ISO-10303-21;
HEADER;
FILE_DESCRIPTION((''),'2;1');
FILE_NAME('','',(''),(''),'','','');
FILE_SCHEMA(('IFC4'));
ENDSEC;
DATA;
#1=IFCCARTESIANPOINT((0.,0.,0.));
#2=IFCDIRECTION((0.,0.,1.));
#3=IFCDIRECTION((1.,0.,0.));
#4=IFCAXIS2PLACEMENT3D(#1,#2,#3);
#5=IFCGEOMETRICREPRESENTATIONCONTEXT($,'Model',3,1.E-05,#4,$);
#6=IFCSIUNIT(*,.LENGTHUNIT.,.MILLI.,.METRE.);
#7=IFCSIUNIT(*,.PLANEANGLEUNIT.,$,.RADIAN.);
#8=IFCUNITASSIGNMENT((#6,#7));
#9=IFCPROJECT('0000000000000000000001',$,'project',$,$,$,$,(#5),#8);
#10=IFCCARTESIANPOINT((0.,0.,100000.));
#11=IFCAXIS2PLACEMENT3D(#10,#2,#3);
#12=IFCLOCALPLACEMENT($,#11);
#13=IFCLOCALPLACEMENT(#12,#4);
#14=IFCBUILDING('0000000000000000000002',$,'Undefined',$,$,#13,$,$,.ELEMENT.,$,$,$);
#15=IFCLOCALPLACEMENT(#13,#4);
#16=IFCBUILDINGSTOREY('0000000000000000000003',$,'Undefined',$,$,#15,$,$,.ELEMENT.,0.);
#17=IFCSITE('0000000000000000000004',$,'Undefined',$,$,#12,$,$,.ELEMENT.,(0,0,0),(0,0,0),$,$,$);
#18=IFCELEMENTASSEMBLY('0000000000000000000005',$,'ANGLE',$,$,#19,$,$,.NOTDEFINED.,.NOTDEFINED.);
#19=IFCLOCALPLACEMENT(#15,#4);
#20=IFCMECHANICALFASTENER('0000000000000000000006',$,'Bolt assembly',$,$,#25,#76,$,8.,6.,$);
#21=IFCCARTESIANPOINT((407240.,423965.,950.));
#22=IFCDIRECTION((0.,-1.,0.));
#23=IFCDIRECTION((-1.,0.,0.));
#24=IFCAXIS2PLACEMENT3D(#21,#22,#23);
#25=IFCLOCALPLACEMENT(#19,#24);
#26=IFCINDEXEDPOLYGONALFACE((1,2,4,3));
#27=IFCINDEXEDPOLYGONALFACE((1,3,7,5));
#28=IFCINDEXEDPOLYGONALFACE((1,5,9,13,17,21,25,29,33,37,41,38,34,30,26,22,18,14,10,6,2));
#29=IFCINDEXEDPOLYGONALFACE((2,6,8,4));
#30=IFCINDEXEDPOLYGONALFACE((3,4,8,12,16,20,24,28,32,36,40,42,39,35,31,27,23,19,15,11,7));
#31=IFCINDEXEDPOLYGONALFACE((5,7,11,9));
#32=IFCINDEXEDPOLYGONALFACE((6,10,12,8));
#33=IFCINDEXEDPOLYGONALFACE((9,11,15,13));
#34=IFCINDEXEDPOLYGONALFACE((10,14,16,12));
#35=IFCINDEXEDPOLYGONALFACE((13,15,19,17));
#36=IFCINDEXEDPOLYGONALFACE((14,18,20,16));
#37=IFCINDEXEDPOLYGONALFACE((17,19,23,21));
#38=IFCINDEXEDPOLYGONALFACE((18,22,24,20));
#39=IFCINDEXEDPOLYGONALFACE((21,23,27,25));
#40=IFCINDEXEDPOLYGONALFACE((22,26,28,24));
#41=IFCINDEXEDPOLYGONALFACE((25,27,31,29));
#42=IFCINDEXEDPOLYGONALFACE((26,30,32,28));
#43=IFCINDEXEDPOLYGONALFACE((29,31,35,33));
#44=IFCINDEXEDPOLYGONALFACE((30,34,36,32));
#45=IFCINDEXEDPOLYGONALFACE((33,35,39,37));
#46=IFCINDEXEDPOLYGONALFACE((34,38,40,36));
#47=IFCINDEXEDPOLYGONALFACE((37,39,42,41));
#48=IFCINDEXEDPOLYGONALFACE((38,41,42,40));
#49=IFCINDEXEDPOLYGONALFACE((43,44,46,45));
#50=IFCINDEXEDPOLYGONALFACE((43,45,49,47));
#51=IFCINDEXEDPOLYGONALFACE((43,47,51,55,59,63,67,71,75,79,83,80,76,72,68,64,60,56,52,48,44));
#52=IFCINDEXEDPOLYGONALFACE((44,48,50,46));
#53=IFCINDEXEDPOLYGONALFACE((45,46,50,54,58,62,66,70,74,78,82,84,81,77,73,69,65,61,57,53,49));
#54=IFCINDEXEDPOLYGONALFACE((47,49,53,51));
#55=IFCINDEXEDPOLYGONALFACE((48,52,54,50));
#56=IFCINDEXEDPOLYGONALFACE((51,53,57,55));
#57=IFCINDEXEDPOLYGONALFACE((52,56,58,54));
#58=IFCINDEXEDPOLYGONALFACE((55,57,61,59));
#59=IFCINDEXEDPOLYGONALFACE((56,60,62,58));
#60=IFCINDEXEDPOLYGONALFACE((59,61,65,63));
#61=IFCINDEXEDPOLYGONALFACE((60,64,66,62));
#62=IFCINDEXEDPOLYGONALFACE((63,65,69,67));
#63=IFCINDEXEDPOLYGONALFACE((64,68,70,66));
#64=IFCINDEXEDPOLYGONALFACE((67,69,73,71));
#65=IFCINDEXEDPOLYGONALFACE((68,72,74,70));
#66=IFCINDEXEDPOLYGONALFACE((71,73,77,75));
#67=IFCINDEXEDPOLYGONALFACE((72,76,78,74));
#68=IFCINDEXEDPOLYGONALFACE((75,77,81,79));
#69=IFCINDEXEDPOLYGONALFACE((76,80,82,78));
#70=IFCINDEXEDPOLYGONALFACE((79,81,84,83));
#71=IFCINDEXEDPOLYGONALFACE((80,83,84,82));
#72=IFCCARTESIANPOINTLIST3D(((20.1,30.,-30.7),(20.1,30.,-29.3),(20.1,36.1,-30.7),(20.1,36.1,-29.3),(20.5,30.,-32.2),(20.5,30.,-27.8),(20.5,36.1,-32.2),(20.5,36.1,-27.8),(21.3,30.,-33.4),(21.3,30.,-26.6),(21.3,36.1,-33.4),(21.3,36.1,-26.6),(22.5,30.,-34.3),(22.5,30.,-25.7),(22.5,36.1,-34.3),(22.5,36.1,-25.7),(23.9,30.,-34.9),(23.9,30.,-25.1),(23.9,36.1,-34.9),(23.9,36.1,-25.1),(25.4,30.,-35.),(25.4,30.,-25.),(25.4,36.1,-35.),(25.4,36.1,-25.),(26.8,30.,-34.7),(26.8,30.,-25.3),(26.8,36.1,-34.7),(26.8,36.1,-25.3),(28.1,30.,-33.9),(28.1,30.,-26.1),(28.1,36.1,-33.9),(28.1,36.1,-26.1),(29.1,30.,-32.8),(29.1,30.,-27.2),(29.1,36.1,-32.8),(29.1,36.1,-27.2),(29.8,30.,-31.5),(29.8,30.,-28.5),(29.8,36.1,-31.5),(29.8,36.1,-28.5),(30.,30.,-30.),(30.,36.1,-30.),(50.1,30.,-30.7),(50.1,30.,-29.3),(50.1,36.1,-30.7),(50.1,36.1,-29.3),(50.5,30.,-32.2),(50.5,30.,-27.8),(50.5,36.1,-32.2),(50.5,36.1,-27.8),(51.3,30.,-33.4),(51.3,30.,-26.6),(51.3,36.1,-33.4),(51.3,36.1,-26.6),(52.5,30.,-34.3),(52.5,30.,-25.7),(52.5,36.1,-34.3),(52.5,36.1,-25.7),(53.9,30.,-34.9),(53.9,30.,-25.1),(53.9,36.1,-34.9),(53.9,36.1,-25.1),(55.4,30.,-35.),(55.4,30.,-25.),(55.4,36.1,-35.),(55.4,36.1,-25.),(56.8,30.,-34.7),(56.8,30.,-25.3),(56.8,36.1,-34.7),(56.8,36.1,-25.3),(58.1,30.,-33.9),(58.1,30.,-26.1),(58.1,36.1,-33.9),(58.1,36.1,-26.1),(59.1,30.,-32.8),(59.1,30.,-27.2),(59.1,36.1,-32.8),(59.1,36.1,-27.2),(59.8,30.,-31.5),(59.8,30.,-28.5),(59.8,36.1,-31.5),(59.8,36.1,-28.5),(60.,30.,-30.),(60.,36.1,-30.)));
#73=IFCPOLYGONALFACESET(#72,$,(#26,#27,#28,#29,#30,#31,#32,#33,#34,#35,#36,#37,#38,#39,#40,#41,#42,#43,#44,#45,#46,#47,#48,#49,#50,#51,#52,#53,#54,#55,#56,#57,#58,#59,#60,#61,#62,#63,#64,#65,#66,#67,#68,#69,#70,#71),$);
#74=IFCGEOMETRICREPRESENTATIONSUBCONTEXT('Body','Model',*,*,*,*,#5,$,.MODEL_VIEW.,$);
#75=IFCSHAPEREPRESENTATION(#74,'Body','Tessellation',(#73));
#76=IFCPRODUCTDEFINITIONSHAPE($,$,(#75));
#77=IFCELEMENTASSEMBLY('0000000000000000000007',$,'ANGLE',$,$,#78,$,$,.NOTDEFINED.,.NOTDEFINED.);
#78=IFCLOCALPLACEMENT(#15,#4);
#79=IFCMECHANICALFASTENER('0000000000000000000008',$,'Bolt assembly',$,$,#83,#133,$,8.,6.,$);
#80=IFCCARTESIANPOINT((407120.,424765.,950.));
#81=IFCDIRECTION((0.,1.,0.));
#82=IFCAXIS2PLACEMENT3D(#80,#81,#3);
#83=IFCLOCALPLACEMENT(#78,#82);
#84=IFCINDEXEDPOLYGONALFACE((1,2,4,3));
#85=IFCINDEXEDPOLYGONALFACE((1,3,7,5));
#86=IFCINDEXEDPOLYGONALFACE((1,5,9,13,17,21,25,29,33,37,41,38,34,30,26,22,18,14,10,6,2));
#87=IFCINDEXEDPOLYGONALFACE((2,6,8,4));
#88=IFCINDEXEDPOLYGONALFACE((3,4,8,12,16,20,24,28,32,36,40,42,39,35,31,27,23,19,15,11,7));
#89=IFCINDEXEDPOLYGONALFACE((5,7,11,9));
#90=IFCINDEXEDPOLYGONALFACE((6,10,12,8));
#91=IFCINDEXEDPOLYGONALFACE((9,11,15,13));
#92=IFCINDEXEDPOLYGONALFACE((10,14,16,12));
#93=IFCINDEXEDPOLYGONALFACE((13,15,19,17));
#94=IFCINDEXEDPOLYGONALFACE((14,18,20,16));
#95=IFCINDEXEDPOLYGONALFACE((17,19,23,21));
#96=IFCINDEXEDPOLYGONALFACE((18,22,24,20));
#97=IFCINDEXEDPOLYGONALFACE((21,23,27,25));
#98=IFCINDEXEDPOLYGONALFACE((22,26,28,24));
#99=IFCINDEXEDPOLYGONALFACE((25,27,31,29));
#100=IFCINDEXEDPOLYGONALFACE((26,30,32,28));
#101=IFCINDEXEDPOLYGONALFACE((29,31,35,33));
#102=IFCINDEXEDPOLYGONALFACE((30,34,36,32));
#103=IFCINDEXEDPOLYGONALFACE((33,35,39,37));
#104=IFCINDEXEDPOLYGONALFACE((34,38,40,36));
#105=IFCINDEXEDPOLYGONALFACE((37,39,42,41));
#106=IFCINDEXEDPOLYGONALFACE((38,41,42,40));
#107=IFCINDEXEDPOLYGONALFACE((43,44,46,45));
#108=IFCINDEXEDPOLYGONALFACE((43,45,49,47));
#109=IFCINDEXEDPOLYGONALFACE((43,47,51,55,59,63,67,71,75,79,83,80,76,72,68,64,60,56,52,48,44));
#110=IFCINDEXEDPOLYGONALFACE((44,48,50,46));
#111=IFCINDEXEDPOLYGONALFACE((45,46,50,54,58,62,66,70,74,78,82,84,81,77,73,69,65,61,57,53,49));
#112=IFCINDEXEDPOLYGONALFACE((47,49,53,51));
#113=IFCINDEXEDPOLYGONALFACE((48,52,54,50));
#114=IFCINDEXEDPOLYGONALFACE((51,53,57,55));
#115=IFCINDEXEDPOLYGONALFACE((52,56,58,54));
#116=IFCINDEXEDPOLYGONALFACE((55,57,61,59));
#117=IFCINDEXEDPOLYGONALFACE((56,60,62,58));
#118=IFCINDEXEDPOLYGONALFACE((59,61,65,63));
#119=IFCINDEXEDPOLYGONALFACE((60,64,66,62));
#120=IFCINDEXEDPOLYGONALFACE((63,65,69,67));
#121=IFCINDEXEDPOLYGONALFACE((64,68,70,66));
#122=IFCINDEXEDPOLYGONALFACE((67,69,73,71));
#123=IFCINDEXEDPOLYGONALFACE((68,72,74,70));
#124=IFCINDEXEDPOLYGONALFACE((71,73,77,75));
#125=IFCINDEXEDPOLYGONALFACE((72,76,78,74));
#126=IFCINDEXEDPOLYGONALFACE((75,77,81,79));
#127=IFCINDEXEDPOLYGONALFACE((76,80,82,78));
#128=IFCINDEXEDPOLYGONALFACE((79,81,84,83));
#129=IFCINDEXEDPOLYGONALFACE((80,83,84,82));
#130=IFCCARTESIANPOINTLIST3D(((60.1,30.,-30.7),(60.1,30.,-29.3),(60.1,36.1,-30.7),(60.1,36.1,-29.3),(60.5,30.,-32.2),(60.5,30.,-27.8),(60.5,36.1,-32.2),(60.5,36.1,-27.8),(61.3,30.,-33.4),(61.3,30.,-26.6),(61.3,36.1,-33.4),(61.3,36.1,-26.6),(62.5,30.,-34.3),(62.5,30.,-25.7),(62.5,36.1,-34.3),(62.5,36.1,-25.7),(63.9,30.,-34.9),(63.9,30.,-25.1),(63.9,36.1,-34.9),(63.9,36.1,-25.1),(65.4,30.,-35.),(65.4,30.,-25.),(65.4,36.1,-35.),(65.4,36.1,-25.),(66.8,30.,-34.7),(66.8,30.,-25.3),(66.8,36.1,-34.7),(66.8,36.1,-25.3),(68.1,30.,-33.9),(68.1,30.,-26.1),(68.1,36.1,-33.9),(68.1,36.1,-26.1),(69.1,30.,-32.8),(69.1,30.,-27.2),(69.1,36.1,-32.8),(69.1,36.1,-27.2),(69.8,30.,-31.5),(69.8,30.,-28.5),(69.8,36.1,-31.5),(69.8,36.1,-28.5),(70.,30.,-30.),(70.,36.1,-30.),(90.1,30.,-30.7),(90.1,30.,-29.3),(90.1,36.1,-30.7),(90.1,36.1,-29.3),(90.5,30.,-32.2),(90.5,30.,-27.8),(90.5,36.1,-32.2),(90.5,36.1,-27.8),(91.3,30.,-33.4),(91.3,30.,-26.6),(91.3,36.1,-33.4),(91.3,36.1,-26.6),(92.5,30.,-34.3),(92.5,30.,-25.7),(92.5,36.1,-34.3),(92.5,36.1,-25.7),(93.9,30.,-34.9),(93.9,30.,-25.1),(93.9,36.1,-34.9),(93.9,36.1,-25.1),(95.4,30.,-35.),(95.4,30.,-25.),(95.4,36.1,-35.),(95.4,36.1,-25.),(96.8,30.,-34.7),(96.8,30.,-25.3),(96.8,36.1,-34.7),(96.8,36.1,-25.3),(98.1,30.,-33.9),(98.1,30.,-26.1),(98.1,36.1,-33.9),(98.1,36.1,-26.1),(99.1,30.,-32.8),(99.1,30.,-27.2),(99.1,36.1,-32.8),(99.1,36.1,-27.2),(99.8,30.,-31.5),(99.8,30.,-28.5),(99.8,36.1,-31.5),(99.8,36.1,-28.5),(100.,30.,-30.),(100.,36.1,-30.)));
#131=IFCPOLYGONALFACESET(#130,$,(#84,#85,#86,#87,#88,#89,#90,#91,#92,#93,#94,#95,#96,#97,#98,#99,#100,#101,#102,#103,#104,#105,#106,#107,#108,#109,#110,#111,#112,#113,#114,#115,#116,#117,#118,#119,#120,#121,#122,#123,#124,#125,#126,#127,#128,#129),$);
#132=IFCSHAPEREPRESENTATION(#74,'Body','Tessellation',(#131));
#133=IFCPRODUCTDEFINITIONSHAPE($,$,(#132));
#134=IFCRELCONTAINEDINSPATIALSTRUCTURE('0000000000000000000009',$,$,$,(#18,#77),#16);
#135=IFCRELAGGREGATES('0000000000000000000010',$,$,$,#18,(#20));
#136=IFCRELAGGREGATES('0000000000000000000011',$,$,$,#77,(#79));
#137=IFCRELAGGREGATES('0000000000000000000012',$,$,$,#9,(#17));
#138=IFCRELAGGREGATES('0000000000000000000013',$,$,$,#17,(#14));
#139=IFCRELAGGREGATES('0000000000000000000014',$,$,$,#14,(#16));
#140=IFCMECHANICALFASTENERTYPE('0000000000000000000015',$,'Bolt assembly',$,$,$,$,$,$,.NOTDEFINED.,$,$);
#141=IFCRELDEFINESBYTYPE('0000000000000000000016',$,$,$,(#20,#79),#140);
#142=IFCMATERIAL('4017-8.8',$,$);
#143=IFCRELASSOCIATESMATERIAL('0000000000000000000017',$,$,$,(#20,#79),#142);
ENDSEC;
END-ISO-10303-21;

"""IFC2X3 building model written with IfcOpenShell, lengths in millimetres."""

from ifc_helpers import new_model, si_unit, frame, origin_with_axes, origin_2d_with_axis, place, context, subcontext, project, spatial, circle, extrude, source, transform, mapped, material, type_object, element, aggregate, save


model = new_model("IFC2X3")

# Units and contexts
model_context = context("Model", 3, precision=1e-05, world=origin_with_axes())
body_context = subcontext(model_context, "Body", "Model", "MODEL_VIEW")
ifc_project = project(units=[si_unit("LENGTHUNIT", "METRE", prefix="MILLI"), si_unit("PLANEANGLEUNIT", "RADIAN")], contexts=[model_context])

# Site, building, storey
site_placement = place(None, frame((0.0, 0.0, 100000.0), z_axis=(0.0, 0.0, 1.0), x_axis=(1.0, 0.0, 0.0)))
site = spatial("IfcSite", under=ifc_project, at=site_placement, Name="Undefined", CompositionType="ELEMENT", RefLatitude=(0, 0, 0), RefLongitude=(0, 0, 0))
building_placement = place(site_placement, origin_with_axes())
building = spatial("IfcBuilding", under=site, at=building_placement, Name="Undefined", CompositionType="ELEMENT")
storey_placement = place(building_placement, origin_with_axes())
storey = spatial("IfcBuildingStorey", under=building, at=storey_placement, Name="Undefined", CompositionType="ELEMENT", Elevation=0.0)

# Shared definitions
ifc_material_1 = material(Name="4017-8.8")
mechanical_fastener_type = type_object("IfcMechanicalFastenerType", Name="Bolt assembly")

# Shared definitions
shared_shape_1 = source(origin_with_axes(), body_context, "Body", "SweptSolid", [
    extrude(circle(Radius=5.0, at=origin_2d_with_axis()), frame((0.0, 30.0, 0.0), z_axis=(0.0, 1.0, 0.0), x_axis=(1.0, 0.0, 0.0)), (0.0, 0.0, 1.0), 6.1),
])

# Element assemblies, mechanical fasteners
assembly_1_placement = place(storey_placement, origin_with_axes())
assembly_1 = element("IfcElementAssembly", 1, at=assembly_1_placement, inside=storey, Name="ANGLE", AssemblyPlace="NOTDEFINED", PredefinedType="NOTDEFINED")
mechanical_fastener_1_placement = place(assembly_1_placement, frame((407240.0, 423965.0, 950.0), z_axis=(0.0, -1.0, 0.0), x_axis=(-1.0, 0.0, 0.0)))
mechanical_fastener_1 = element("IfcMechanicalFastener", 2, at=mechanical_fastener_1_placement, type_object=mechanical_fastener_type, material=ifc_material_1, Name="Bolt assembly", NominalDiameter=8.0, NominalLength=6.0, context=body_context, shape_type="MappedRepresentation", body=[
    mapped(shared_shape_1, transform((25.0, 0.0, -30.0))),
    mapped(shared_shape_1, transform((55.0, 0.0, -30.0))),
])
aggregate(assembly_1, [mechanical_fastener_1])
assembly_2_placement = place(storey_placement, origin_with_axes())
assembly_2 = element("IfcElementAssembly", 3, at=assembly_2_placement, inside=storey, Name="ANGLE", AssemblyPlace="NOTDEFINED", PredefinedType="NOTDEFINED")
mechanical_fastener_2_placement = place(assembly_2_placement, frame((407120.0, 424765.0, 950.0), z_axis=(0.0, 1.0, 0.0), x_axis=(1.0, 0.0, 0.0)))
mechanical_fastener_2 = element("IfcMechanicalFastener", 4, at=mechanical_fastener_2_placement, type_object=mechanical_fastener_type, material=ifc_material_1, Name="Bolt assembly", NominalDiameter=8.0, NominalLength=6.0, context=body_context, shape_type="MappedRepresentation", body=[
    mapped(shared_shape_1, transform((95.0, 0.0, -30.0))),
    mapped(shared_shape_1, transform((65.0, 0.0, -30.0))),
])
aggregate(assembly_2, [mechanical_fastener_2])

save(model, "model.ifc")
